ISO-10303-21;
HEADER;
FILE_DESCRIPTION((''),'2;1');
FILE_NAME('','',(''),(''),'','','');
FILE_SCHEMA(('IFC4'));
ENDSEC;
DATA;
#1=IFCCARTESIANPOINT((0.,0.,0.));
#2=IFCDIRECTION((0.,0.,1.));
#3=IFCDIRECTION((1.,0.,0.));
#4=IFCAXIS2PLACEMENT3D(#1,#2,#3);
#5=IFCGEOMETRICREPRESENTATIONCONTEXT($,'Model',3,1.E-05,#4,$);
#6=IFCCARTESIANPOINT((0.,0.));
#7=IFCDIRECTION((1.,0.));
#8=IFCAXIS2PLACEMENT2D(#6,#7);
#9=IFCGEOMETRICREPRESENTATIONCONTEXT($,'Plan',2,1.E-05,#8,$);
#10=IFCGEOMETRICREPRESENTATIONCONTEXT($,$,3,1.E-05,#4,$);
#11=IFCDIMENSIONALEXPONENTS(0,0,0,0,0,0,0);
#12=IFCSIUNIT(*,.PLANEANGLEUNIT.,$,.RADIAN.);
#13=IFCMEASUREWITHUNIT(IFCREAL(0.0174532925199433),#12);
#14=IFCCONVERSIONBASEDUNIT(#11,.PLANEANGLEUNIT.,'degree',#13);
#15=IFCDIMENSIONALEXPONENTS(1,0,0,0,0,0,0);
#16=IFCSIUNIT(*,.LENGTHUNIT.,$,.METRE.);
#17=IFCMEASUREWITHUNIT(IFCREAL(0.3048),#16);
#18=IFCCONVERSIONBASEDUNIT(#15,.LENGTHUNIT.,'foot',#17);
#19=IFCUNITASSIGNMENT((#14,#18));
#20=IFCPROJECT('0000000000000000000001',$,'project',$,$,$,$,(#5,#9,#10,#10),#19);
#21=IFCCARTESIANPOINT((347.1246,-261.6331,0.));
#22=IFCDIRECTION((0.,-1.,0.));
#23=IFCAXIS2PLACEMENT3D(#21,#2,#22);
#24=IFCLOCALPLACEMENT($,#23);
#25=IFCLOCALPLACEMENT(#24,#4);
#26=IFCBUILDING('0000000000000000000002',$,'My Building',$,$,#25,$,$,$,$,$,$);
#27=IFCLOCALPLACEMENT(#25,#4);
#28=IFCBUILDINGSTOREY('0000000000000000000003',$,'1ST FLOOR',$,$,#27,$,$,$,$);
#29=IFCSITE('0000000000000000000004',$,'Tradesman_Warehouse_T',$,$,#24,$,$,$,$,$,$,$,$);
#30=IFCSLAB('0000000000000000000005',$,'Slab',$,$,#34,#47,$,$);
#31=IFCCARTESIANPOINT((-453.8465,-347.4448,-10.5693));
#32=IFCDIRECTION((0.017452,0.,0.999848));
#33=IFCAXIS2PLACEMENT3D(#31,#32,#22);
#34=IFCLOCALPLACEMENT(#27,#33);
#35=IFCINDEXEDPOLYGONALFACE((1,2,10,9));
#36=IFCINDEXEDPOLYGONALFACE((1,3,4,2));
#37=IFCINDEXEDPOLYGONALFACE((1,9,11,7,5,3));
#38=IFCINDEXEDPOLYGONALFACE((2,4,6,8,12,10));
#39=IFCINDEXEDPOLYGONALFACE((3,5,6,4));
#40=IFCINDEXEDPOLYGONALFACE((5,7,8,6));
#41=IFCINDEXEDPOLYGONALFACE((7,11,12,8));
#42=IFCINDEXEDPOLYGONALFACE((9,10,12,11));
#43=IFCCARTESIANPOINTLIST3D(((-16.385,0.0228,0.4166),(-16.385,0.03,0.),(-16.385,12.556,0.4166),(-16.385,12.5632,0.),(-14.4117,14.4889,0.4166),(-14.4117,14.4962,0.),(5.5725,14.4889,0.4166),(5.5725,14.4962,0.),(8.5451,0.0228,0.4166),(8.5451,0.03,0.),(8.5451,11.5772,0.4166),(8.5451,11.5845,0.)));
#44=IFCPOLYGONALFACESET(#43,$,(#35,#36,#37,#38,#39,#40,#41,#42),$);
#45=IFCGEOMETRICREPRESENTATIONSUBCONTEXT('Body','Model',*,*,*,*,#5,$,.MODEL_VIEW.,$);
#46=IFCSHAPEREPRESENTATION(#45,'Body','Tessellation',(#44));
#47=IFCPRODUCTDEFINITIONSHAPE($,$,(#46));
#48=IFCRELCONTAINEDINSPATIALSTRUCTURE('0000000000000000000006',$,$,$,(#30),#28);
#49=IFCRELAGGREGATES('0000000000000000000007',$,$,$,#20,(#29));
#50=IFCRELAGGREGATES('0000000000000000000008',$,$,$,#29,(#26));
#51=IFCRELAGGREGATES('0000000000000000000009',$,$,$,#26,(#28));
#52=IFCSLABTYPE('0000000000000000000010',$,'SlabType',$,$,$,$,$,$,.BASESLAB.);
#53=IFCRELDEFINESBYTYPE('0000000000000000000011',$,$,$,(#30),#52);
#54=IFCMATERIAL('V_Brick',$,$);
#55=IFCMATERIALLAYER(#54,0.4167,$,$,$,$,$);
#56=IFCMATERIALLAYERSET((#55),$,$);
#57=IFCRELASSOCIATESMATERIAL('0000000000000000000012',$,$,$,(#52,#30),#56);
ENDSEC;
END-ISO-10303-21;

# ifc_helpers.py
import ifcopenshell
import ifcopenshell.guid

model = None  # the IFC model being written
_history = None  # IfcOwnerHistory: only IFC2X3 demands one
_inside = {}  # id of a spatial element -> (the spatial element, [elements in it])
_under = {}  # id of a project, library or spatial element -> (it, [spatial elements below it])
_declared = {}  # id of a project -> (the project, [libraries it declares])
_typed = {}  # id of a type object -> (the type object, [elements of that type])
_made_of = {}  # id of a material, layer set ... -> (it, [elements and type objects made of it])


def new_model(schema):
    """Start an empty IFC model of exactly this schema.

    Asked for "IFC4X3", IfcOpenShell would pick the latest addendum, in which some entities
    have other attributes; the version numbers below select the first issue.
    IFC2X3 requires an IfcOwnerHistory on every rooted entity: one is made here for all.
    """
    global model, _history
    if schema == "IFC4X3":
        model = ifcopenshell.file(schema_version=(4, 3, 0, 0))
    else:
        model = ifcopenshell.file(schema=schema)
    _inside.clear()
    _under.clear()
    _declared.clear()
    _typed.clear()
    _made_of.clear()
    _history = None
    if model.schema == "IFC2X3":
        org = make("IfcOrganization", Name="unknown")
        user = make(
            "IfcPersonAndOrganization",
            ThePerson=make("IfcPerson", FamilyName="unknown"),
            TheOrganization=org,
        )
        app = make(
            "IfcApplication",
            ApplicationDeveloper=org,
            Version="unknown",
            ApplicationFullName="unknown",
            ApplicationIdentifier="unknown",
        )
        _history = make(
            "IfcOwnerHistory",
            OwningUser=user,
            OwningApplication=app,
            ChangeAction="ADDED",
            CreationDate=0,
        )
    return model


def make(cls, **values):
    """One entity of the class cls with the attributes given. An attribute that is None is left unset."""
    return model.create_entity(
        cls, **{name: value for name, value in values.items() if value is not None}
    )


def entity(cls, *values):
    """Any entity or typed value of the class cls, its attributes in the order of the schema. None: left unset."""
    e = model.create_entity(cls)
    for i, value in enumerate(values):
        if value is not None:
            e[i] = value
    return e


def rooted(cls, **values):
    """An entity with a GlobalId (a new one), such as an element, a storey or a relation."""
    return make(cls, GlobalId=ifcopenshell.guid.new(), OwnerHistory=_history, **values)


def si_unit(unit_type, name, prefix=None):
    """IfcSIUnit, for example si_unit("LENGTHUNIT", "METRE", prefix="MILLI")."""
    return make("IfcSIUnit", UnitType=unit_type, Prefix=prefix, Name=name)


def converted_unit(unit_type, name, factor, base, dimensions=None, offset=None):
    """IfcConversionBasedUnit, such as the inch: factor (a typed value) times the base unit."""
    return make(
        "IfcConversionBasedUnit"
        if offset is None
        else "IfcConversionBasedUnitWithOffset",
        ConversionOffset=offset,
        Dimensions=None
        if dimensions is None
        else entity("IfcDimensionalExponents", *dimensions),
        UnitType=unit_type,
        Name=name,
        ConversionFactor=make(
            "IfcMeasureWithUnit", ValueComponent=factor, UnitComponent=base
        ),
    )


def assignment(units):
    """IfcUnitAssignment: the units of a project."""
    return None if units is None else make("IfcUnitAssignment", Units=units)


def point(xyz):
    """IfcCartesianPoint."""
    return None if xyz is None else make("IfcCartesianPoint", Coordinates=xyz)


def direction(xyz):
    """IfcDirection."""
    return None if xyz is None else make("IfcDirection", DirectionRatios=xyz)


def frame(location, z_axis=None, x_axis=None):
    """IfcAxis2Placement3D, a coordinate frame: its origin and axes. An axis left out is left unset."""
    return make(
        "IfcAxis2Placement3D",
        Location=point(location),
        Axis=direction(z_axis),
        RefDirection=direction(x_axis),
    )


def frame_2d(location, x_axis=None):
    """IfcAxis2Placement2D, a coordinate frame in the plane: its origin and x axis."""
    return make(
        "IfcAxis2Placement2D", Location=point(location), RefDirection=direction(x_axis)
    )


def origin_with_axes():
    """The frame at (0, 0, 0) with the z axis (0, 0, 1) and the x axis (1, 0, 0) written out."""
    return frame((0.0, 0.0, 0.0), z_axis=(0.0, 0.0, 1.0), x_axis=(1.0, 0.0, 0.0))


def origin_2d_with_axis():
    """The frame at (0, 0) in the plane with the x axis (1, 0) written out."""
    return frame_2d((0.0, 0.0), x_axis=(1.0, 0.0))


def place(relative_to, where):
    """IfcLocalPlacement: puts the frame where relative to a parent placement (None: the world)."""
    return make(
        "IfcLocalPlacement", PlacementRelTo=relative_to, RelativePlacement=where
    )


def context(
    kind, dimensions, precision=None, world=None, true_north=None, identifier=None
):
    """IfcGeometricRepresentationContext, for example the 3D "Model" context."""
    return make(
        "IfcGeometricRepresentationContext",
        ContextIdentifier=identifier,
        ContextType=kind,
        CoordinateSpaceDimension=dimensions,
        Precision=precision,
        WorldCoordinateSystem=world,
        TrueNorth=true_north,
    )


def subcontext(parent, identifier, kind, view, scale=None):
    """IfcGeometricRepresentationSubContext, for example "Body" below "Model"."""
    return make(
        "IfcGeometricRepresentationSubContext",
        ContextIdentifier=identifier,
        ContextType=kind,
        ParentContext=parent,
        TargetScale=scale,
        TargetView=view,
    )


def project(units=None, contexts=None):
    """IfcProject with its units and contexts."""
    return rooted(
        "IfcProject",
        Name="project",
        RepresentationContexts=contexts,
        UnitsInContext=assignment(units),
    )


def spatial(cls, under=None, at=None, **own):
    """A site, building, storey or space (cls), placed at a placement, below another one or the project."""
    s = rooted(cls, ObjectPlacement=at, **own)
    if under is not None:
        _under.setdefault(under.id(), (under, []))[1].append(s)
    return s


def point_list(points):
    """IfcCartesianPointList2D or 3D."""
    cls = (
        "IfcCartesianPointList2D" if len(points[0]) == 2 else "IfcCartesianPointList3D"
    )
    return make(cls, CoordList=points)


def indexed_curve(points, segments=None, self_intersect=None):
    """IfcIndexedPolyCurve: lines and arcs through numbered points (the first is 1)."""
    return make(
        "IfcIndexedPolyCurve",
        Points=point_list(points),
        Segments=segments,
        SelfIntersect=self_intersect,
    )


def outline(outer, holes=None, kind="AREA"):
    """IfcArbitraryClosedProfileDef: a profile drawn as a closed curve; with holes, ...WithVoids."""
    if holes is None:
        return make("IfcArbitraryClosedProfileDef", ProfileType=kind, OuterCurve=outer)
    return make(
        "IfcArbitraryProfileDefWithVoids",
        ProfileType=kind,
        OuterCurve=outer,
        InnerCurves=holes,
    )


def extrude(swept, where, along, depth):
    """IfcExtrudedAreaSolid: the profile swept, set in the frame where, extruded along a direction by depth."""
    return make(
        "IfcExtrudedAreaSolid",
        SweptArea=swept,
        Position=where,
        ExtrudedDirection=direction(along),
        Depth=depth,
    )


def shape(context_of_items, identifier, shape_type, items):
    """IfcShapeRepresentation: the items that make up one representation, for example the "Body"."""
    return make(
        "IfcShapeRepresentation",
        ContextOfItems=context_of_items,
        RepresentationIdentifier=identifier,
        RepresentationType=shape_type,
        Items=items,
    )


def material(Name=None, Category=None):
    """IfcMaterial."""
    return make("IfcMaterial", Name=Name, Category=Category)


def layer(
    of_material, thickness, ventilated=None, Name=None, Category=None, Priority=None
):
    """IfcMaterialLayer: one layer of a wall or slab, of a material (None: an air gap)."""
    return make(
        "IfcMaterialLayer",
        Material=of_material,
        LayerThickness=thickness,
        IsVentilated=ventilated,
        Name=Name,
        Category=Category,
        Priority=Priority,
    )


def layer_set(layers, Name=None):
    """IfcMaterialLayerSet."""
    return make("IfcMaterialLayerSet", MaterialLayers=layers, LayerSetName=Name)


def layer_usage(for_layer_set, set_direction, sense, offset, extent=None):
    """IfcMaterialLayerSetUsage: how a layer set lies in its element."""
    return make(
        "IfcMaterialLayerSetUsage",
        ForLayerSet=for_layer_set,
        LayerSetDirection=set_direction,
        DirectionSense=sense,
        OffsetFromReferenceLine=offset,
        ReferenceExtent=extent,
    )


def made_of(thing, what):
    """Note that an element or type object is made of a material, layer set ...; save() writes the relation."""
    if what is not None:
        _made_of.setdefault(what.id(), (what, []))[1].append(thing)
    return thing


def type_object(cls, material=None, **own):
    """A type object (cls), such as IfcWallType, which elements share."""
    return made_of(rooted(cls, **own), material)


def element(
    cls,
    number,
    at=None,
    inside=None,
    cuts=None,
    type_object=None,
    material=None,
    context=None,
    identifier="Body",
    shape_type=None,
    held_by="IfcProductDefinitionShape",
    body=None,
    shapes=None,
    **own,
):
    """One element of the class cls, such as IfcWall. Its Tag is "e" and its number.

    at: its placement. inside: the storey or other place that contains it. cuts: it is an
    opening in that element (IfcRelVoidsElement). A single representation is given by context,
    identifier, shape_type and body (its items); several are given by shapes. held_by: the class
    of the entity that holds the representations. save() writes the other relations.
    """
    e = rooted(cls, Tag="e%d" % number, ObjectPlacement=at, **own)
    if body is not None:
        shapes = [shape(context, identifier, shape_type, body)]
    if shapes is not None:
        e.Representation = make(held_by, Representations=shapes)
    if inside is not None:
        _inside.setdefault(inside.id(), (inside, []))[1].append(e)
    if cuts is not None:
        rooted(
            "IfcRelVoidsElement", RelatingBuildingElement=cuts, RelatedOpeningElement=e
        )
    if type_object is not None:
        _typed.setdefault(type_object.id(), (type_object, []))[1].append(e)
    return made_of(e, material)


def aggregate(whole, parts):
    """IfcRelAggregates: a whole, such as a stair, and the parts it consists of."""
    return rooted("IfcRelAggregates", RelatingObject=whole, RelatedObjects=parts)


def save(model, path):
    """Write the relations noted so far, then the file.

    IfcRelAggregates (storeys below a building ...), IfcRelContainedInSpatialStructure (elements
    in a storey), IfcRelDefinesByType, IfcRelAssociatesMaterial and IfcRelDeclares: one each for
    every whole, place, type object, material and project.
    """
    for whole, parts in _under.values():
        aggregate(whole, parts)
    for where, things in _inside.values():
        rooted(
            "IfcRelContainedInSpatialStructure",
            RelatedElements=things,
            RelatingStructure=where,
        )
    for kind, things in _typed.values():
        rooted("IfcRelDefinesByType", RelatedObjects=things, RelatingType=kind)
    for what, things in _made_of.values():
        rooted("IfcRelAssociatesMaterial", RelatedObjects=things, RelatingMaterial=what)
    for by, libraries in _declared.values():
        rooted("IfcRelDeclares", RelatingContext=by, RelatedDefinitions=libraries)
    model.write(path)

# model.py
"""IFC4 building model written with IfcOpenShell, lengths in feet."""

from ifc_helpers import new_model, entity, si_unit, converted_unit, frame, origin_with_axes, origin_2d_with_axis, place, context, subcontext, project, spatial, indexed_curve, outline, extrude, material, layer, layer_set, layer_usage, type_object, element, save


model = new_model("IFC4")

# Units and contexts
model_context = context("Model", 3, precision=1e-05, world=origin_with_axes())
plan_context = context("Plan", 2, precision=1e-05, world=origin_2d_with_axis())
context_of_model = context(None, 3, precision=1e-05, world=origin_with_axes())
body_context = subcontext(model_context, "Body", "Model", "MODEL_VIEW")
ifc_project = project(units=[converted_unit("PLANEANGLEUNIT", "degree", entity("IfcReal", 0.0174532925199433), si_unit("PLANEANGLEUNIT", "RADIAN"), dimensions=[0, 0, 0, 0, 0, 0, 0]), converted_unit("LENGTHUNIT", "foot", entity("IfcReal", 0.3048), si_unit("LENGTHUNIT", "METRE"), dimensions=[1, 0, 0, 0, 0, 0, 0])], contexts=[model_context, plan_context, context_of_model, context_of_model])

# Site, building, storey
site_placement = place(None, frame((347.1246, -261.6331, 0.0), z_axis=(0.0, 0.0, 1.0), x_axis=(0.0, -1.0, 0.0)))
site = spatial("IfcSite", under=ifc_project, at=site_placement, Name="Tradesman_Warehouse_T")
building_placement = place(site_placement, frame((0.0, 0.0, 0.0), z_axis=(0.0, 0.0, 1.0), x_axis=(1.0, 0.0, 0.0)))
building = spatial("IfcBuilding", under=site, at=building_placement, Name="My Building")
storey_placement = place(building_placement, frame((0.0, 0.0, 0.0), z_axis=(0.0, 0.0, 1.0), x_axis=(1.0, 0.0, 0.0)))
storey = spatial("IfcBuildingStorey", under=building, at=storey_placement, Name="1ST FLOOR")

# Slab
ifc_material_1 = material(Name="V_Brick")
ifc_layer_1 = layer(ifc_material_1, 0.4167)
ifc_layer_set_1 = layer_set([ifc_layer_1])
ifc_layer_usage_1 = layer_usage(ifc_layer_set_1, "AXIS3", "POSITIVE", 0.0)
slab_type = type_object("IfcSlabType", Name="SlabType", PredefinedType="BASESLAB", material=ifc_layer_set_1)
slab_placement = place(storey_placement, frame((-453.8465, -347.4448, -10.5693), z_axis=(0.017452, 0.0, 0.999848), x_axis=(0.0, -1.0, 0.0)))
element("IfcSlab", 1, at=slab_placement, inside=storey, type_object=slab_type, material=ifc_layer_usage_1, Name="Slab", context=body_context, shape_type="SweptSolid", body=[
    extrude(outline(indexed_curve([(-16.385, 0.03), (-16.385, 12.5632), (-14.4117, 14.4962), (5.5725, 14.4962), (8.5451, 11.5845), (8.5451, 0.03), (-16.385, 0.03)])), None, (0.0, -0.017452, 0.999848), 0.4167),
])

save(model, "model.ifc")
